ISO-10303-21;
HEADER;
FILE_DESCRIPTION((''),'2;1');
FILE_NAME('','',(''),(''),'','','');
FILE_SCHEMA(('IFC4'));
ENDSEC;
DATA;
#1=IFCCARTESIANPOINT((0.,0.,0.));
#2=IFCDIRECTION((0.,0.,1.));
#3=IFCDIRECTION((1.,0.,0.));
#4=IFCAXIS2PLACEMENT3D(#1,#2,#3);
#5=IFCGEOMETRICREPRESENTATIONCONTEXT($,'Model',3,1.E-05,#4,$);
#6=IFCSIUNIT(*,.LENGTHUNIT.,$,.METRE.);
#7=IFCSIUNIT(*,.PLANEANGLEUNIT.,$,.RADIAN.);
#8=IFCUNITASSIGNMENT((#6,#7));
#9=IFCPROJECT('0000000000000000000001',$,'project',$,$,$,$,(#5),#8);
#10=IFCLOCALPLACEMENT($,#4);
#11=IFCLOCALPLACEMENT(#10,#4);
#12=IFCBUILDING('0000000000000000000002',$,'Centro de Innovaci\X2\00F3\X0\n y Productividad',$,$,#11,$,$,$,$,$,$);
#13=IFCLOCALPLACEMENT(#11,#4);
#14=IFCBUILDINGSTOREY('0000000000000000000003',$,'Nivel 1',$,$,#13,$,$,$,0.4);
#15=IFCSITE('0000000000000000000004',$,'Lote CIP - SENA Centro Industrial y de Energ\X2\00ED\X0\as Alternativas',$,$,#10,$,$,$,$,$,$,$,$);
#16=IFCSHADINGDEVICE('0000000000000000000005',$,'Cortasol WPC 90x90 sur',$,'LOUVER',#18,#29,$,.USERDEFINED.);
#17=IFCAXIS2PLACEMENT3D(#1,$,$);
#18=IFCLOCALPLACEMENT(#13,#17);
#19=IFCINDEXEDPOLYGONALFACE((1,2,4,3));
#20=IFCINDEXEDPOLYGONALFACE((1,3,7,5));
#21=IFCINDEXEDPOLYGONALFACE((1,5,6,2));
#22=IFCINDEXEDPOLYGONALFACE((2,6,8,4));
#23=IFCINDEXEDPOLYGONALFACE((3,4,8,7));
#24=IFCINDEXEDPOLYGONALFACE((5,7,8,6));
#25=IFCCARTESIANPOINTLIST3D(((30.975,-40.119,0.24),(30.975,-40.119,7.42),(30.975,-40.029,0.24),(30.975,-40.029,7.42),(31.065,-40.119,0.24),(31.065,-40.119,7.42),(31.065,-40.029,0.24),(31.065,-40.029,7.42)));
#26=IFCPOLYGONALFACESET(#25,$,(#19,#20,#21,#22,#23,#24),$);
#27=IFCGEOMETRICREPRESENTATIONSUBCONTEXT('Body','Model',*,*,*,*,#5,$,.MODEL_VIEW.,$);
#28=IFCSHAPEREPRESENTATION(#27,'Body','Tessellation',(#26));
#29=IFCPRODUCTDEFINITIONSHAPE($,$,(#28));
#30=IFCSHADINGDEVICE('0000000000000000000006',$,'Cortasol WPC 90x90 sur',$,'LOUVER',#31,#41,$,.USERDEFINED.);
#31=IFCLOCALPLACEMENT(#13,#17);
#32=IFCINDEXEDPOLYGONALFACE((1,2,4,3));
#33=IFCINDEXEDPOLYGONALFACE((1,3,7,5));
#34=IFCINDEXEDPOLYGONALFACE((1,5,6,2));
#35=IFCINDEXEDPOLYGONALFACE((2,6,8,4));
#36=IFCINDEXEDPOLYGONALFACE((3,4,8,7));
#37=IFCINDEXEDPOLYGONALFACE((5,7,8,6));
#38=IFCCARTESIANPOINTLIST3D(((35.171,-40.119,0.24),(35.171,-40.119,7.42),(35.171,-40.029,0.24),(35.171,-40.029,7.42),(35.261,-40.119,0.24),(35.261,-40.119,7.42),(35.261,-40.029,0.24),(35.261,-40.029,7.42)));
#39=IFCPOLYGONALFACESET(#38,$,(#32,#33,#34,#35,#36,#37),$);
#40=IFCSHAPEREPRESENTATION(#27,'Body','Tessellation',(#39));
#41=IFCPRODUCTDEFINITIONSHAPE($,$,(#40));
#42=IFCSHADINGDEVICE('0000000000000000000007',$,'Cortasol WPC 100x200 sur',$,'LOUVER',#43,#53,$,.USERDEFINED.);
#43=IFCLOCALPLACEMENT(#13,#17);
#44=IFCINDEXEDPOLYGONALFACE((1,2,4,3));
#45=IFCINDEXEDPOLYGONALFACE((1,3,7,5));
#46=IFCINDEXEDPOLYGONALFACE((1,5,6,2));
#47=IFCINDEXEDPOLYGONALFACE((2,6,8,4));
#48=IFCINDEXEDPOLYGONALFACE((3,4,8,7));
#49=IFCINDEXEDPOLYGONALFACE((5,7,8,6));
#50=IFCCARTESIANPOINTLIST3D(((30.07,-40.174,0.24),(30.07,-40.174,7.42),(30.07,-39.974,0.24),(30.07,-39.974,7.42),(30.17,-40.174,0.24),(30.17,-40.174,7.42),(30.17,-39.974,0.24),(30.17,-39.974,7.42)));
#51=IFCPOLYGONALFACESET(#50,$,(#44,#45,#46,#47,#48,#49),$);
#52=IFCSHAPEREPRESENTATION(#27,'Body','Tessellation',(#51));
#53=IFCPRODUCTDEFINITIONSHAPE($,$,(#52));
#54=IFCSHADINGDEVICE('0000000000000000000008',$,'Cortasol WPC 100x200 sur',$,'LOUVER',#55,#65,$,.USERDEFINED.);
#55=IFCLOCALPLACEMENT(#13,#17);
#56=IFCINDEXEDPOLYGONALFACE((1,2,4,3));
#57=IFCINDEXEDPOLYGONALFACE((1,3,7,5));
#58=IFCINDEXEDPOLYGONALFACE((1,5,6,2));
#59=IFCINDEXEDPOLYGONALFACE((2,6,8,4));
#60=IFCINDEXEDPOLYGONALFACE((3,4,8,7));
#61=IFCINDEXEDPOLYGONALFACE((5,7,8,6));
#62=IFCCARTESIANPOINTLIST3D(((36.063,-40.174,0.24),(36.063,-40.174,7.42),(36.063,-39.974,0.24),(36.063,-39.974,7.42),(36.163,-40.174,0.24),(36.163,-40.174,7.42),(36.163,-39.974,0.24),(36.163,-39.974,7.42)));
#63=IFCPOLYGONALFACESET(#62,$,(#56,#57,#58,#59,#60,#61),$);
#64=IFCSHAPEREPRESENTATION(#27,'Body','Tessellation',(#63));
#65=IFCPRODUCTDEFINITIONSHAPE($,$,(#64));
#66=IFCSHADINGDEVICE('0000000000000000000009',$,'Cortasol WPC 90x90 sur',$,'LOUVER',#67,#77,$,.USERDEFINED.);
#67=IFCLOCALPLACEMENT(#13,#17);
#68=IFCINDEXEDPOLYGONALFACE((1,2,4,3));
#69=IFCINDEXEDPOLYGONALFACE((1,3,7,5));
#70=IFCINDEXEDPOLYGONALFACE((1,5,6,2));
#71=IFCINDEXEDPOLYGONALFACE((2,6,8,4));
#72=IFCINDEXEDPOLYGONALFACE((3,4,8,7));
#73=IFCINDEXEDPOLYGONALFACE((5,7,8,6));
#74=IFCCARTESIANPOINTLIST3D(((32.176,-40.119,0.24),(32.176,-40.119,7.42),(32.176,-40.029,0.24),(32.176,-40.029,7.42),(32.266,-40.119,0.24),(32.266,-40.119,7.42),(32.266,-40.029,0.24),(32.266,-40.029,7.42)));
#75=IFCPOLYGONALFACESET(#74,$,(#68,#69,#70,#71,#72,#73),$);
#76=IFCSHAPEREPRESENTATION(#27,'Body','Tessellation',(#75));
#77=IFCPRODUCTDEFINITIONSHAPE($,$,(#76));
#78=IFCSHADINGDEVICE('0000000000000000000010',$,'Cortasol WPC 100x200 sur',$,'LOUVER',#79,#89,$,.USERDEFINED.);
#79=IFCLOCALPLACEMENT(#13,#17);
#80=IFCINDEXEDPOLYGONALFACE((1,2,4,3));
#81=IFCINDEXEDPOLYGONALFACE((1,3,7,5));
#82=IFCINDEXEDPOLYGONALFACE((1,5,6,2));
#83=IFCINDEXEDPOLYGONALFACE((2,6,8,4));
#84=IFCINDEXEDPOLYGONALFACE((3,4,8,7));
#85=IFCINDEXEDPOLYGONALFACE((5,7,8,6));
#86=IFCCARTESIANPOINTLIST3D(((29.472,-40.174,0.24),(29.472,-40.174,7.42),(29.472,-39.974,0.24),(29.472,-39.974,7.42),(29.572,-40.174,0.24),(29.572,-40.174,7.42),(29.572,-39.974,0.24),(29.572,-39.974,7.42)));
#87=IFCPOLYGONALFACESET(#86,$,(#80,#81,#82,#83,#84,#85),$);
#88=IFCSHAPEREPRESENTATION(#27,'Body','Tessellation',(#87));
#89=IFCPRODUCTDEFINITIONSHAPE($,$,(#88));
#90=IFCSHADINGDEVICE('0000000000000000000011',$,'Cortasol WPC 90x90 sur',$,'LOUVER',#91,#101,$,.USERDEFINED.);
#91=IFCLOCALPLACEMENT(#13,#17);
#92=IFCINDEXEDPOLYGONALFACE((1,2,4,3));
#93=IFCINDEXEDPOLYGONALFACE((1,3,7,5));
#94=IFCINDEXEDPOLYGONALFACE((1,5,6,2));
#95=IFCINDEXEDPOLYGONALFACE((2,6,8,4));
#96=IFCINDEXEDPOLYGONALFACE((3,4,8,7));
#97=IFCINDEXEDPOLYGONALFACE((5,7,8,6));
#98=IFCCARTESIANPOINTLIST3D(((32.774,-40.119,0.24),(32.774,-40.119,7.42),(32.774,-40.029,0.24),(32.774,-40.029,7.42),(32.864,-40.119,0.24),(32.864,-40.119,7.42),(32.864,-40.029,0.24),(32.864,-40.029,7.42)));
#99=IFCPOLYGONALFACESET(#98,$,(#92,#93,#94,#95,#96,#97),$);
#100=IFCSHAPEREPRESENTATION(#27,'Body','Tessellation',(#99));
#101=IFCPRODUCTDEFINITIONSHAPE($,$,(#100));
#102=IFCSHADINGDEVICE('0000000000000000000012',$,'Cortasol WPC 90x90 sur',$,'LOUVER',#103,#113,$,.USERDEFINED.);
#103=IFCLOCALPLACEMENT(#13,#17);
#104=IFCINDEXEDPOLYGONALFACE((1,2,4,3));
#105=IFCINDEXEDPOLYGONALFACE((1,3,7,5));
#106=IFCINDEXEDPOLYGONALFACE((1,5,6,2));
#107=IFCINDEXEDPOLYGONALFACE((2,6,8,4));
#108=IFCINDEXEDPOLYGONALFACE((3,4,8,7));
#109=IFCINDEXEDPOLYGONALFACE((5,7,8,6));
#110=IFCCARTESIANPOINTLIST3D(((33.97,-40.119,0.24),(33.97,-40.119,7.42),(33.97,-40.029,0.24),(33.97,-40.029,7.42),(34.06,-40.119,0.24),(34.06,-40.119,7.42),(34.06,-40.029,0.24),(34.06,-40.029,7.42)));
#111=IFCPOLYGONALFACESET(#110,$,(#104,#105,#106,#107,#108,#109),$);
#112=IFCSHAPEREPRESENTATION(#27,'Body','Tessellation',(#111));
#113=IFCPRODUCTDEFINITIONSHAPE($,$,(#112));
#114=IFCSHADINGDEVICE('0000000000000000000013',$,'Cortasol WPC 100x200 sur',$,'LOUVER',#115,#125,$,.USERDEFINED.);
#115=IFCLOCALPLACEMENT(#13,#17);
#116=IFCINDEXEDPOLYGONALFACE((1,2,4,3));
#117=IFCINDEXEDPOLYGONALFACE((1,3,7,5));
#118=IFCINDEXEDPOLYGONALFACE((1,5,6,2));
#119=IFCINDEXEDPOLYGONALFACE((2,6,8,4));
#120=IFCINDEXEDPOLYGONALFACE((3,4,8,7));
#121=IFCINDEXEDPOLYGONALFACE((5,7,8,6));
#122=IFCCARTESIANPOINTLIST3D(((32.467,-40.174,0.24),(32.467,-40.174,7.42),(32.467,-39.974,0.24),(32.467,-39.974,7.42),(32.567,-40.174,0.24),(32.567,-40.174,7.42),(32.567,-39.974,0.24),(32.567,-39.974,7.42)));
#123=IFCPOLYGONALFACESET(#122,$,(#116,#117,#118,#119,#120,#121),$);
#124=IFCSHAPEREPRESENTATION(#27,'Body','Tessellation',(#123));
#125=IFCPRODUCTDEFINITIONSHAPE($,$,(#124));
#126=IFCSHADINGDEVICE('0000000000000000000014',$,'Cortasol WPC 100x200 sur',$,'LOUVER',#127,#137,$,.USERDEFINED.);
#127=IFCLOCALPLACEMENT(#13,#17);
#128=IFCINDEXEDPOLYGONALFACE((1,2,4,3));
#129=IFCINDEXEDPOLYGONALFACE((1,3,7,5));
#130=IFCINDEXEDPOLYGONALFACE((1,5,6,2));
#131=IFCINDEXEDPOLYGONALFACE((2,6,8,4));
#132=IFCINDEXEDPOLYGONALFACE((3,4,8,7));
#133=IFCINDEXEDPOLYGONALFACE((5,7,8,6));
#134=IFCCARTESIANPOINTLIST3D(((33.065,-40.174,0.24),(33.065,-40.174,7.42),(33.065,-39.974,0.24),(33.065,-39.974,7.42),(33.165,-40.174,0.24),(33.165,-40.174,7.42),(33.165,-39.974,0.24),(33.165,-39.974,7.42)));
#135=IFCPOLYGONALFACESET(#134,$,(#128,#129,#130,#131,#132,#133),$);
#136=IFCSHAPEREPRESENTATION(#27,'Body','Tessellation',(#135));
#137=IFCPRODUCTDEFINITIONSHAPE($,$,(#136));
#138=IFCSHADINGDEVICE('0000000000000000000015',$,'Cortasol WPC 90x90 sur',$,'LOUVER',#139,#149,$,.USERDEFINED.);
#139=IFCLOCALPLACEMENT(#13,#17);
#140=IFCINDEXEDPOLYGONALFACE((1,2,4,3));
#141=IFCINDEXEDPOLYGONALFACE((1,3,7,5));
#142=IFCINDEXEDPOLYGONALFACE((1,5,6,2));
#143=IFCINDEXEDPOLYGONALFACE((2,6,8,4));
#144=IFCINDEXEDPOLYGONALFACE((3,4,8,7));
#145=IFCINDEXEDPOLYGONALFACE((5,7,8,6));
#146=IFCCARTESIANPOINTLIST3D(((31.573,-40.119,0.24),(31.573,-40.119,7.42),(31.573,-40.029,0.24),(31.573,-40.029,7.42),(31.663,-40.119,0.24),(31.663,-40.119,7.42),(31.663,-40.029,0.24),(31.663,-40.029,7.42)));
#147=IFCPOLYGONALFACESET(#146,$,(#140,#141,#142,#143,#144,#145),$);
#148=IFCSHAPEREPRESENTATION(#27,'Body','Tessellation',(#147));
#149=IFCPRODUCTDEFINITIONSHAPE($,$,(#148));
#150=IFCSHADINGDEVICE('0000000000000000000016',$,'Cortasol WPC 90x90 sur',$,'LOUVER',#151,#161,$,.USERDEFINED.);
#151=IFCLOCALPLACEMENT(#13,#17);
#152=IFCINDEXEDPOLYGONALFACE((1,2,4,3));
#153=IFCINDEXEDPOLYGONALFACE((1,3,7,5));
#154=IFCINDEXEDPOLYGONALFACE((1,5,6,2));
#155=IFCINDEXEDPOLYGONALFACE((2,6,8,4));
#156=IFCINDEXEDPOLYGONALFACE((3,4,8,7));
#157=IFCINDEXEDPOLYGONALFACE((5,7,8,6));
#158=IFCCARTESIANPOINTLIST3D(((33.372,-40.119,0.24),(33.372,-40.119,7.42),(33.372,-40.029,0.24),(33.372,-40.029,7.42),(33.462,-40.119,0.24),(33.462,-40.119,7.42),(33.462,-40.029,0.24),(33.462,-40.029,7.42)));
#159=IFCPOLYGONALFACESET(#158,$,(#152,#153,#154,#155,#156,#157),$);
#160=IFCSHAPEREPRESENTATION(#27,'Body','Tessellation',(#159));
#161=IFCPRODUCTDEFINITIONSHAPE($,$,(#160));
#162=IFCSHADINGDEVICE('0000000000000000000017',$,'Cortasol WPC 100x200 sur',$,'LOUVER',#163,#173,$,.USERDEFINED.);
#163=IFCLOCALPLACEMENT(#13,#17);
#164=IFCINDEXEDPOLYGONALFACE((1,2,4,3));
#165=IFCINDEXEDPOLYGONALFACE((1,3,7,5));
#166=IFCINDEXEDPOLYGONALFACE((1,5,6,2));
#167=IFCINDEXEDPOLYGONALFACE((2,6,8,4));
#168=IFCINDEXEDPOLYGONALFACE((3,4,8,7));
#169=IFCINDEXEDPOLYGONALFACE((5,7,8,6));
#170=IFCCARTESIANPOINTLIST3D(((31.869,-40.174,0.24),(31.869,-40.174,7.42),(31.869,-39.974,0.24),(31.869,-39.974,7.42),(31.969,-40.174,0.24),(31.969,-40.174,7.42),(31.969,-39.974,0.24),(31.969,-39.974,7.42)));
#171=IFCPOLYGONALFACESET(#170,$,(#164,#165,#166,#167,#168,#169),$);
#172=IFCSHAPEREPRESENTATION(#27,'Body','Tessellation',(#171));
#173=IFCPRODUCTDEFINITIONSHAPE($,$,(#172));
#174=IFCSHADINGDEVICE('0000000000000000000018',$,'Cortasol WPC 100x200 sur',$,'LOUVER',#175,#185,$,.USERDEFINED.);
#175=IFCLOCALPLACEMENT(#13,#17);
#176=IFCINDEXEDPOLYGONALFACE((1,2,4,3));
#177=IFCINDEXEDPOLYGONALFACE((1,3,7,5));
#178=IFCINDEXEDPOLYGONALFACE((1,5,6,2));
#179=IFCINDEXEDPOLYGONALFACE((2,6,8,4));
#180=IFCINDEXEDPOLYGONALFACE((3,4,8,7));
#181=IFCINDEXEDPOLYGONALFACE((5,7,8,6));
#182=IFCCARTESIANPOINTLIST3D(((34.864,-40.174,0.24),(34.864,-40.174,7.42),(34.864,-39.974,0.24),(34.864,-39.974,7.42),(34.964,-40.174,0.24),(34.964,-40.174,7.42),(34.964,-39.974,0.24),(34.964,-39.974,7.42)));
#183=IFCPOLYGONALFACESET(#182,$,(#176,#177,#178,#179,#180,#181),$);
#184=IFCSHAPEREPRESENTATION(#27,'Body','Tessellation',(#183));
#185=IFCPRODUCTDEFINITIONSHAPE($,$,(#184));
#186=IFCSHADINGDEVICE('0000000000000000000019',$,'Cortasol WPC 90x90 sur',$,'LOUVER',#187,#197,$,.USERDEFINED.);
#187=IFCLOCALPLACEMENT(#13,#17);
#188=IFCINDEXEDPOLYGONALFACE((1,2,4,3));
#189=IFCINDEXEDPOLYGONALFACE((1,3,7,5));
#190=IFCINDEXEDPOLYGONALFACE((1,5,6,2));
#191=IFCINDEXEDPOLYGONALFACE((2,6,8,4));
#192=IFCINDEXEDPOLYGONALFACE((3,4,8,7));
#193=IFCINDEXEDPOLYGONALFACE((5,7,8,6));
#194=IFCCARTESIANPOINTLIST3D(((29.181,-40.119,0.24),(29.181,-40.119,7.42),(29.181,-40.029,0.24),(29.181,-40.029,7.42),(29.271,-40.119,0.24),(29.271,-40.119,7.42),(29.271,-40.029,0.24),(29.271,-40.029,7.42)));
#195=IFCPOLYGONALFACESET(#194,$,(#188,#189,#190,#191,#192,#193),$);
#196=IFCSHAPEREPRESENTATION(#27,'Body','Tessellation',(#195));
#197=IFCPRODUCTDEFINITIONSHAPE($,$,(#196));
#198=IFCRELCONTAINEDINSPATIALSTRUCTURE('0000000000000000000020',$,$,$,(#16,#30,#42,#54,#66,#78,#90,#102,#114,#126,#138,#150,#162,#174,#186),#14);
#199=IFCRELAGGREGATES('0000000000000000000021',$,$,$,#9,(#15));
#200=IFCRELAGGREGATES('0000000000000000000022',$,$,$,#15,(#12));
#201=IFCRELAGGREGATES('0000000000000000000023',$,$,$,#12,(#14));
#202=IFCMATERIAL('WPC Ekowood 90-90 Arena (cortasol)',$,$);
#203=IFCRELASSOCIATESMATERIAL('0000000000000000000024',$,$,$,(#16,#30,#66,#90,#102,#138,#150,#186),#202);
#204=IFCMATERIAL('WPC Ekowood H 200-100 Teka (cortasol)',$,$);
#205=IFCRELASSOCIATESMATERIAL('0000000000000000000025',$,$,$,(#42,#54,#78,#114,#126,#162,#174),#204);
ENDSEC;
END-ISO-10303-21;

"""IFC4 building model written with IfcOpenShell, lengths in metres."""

from ifc_helpers import new_model, si_unit, frame, origin_with_axes, place, context, subcontext, project, spatial, polyline, outline, extrude, material, element, save


model = new_model("IFC4")

# Units and contexts
model_context = context("Model", 3, precision=1e-05, world=origin_with_axes())
body_context = subcontext(model_context, "Body", "Model", "MODEL_VIEW")
ifc_project = project(units=[si_unit("LENGTHUNIT", "METRE"), si_unit("PLANEANGLEUNIT", "RADIAN")], contexts=[model_context])

# Site, building, storey
site_placement = place(None, origin_with_axes())
site = spatial("IfcSite", under=ifc_project, at=site_placement, Name="Lote CIP - SENA Centro Industrial y de Energías Alternativas")
building_placement = place(site_placement, origin_with_axes())
building = spatial("IfcBuilding", under=site, at=building_placement, Name="Centro de Innovación y Productividad")
storey_placement = place(building_placement, origin_with_axes())
storey = spatial("IfcBuildingStorey", under=building, at=storey_placement, Name="Nivel 1", Elevation=0.4)

# Shading devices
ifc_material_1 = material(Name="WPC Ekowood 90-90 Arena (cortasol)")
shading_device_1_placement = place(storey_placement, origin_with_axes())
element("IfcShadingDevice", 1, at=shading_device_1_placement, inside=storey, material=ifc_material_1, Name="Cortasol WPC 90x90 sur", ObjectType="LOUVER", PredefinedType="USERDEFINED", context=body_context, shape_type="SweptSolid", body=[
    extrude(outline(polyline([(30.975, -40.119), (30.975, -40.029), (31.065, -40.029), (31.065, -40.119), (30.975, -40.119)])), frame((0.0, 0.0, 0.24)), (0.0, 0.0, 1.0), 7.18),
])
shading_device_2_placement = place(storey_placement, origin_with_axes())
element("IfcShadingDevice", 2, at=shading_device_2_placement, inside=storey, material=ifc_material_1, Name="Cortasol WPC 90x90 sur", ObjectType="LOUVER", PredefinedType="USERDEFINED", context=body_context, shape_type="SweptSolid", body=[
    extrude(outline(polyline([(35.171, -40.119), (35.171, -40.029), (35.261, -40.029), (35.261, -40.119), (35.171, -40.119)])), frame((0.0, 0.0, 0.24)), (0.0, 0.0, 1.0), 7.18),
])
ifc_material_2 = material(Name="WPC Ekowood H 200-100 Teka (cortasol)")
shading_device_3_placement = place(storey_placement, origin_with_axes())
element("IfcShadingDevice", 3, at=shading_device_3_placement, inside=storey, material=ifc_material_2, Name="Cortasol WPC 100x200 sur", ObjectType="LOUVER", PredefinedType="USERDEFINED", context=body_context, shape_type="SweptSolid", body=[
    extrude(outline(polyline([(30.07, -40.174), (30.07, -39.974), (30.17, -39.974), (30.17, -40.174), (30.07, -40.174)])), frame((0.0, 0.0, 0.24)), (0.0, 0.0, 1.0), 7.18),
])
shading_device_4_placement = place(storey_placement, origin_with_axes())
element("IfcShadingDevice", 4, at=shading_device_4_placement, inside=storey, material=ifc_material_2, Name="Cortasol WPC 100x200 sur", ObjectType="LOUVER", PredefinedType="USERDEFINED", context=body_context, shape_type="SweptSolid", body=[
    extrude(outline(polyline([(36.063, -40.174), (36.063, -39.974), (36.163, -39.974), (36.163, -40.174), (36.063, -40.174)])), frame((0.0, 0.0, 0.24)), (0.0, 0.0, 1.0), 7.18),
])
shading_device_5_placement = place(storey_placement, origin_with_axes())
element("IfcShadingDevice", 5, at=shading_device_5_placement, inside=storey, material=ifc_material_1, Name="Cortasol WPC 90x90 sur", ObjectType="LOUVER", PredefinedType="USERDEFINED", context=body_context, shape_type="SweptSolid", body=[
    extrude(outline(polyline([(32.176, -40.119), (32.176, -40.029), (32.266, -40.029), (32.266, -40.119), (32.176, -40.119)])), frame((0.0, 0.0, 0.24)), (0.0, 0.0, 1.0), 7.18),
])
shading_device_6_placement = place(storey_placement, origin_with_axes())
element("IfcShadingDevice", 6, at=shading_device_6_placement, inside=storey, material=ifc_material_2, Name="Cortasol WPC 100x200 sur", ObjectType="LOUVER", PredefinedType="USERDEFINED", context=body_context, shape_type="SweptSolid", body=[
    extrude(outline(polyline([(29.472, -40.174), (29.472, -39.974), (29.572, -39.974), (29.572, -40.174), (29.472, -40.174)])), frame((0.0, 0.0, 0.24)), (0.0, 0.0, 1.0), 7.18),
])
shading_device_7_placement = place(storey_placement, origin_with_axes())
element("IfcShadingDevice", 7, at=shading_device_7_placement, inside=storey, material=ifc_material_1, Name="Cortasol WPC 90x90 sur", ObjectType="LOUVER", PredefinedType="USERDEFINED", context=body_context, shape_type="SweptSolid", body=[
    extrude(outline(polyline([(32.774, -40.119), (32.774, -40.029), (32.864, -40.029), (32.864, -40.119), (32.774, -40.119)])), frame((0.0, 0.0, 0.24)), (0.0, 0.0, 1.0), 7.18),
])
shading_device_8_placement = place(storey_placement, origin_with_axes())
element("IfcShadingDevice", 8, at=shading_device_8_placement, inside=storey, material=ifc_material_1, Name="Cortasol WPC 90x90 sur", ObjectType="LOUVER", PredefinedType="USERDEFINED", context=body_context, shape_type="SweptSolid", body=[
    extrude(outline(polyline([(33.97, -40.119), (33.97, -40.029), (34.06, -40.029), (34.06, -40.119), (33.97, -40.119)])), frame((0.0, 0.0, 0.24)), (0.0, 0.0, 1.0), 7.18),
])
shading_device_9_placement = place(storey_placement, origin_with_axes())
element("IfcShadingDevice", 9, at=shading_device_9_placement, inside=storey, material=ifc_material_2, Name="Cortasol WPC 100x200 sur", ObjectType="LOUVER", PredefinedType="USERDEFINED", context=body_context, shape_type="SweptSolid", body=[
    extrude(outline(polyline([(32.467, -40.174), (32.467, -39.974), (32.567, -39.974), (32.567, -40.174), (32.467, -40.174)])), frame((0.0, 0.0, 0.24)), (0.0, 0.0, 1.0), 7.18),
])
shading_device_10_placement = place(storey_placement, origin_with_axes())
element("IfcShadingDevice", 10, at=shading_device_10_placement, inside=storey, material=ifc_material_2, Name="Cortasol WPC 100x200 sur", ObjectType="LOUVER", PredefinedType="USERDEFINED", context=body_context, shape_type="SweptSolid", body=[
    extrude(outline(polyline([(33.065, -40.174), (33.065, -39.974), (33.165, -39.974), (33.165, -40.174), (33.065, -40.174)])), frame((0.0, 0.0, 0.24)), (0.0, 0.0, 1.0), 7.18),
])
shading_device_11_placement = place(storey_placement, origin_with_axes())
element("IfcShadingDevice", 11, at=shading_device_11_placement, inside=storey, material=ifc_material_1, Name="Cortasol WPC 90x90 sur", ObjectType="LOUVER", PredefinedType="USERDEFINED", context=body_context, shape_type="SweptSolid", body=[
    extrude(outline(polyline([(31.573, -40.119), (31.573, -40.029), (31.663, -40.029), (31.663, -40.119), (31.573, -40.119)])), frame((0.0, 0.0, 0.24)), (0.0, 0.0, 1.0), 7.18),
])
shading_device_12_placement = place(storey_placement, origin_with_axes())
element("IfcShadingDevice", 12, at=shading_device_12_placement, inside=storey, material=ifc_material_1, Name="Cortasol WPC 90x90 sur", ObjectType="LOUVER", PredefinedType="USERDEFINED", context=body_context, shape_type="SweptSolid", body=[
    extrude(outline(polyline([(33.372, -40.119), (33.372, -40.029), (33.462, -40.029), (33.462, -40.119), (33.372, -40.119)])), frame((0.0, 0.0, 0.24)), (0.0, 0.0, 1.0), 7.18),
])
shading_device_13_placement = place(storey_placement, origin_with_axes())
element("IfcShadingDevice", 13, at=shading_device_13_placement, inside=storey, material=ifc_material_2, Name="Cortasol WPC 100x200 sur", ObjectType="LOUVER", PredefinedType="USERDEFINED", context=body_context, shape_type="SweptSolid", body=[
    extrude(outline(polyline([(31.869, -40.174), (31.869, -39.974), (31.969, -39.974), (31.969, -40.174), (31.869, -40.174)])), frame((0.0, 0.0, 0.24)), (0.0, 0.0, 1.0), 7.18),
])
shading_device_14_placement = place(storey_placement, origin_with_axes())
element("IfcShadingDevice", 14, at=shading_device_14_placement, inside=storey, material=ifc_material_2, Name="Cortasol WPC 100x200 sur", ObjectType="LOUVER", PredefinedType="USERDEFINED", context=body_context, shape_type="SweptSolid", body=[
    extrude(outline(polyline([(34.864, -40.174), (34.864, -39.974), (34.964, -39.974), (34.964, -40.174), (34.864, -40.174)])), frame((0.0, 0.0, 0.24)), (0.0, 0.0, 1.0), 7.18),
])
shading_device_15_placement = place(storey_placement, origin_with_axes())
element("IfcShadingDevice", 15, at=shading_device_15_placement, inside=storey, material=ifc_material_1, Name="Cortasol WPC 90x90 sur", ObjectType="LOUVER", PredefinedType="USERDEFINED", context=body_context, shape_type="SweptSolid", body=[
    extrude(outline(polyline([(29.181, -40.119), (29.181, -40.029), (29.271, -40.029), (29.271, -40.119), (29.181, -40.119)])), frame((0.0, 0.0, 0.24)), (0.0, 0.0, 1.0), 7.18),
])

save(model, "model.ifc")
